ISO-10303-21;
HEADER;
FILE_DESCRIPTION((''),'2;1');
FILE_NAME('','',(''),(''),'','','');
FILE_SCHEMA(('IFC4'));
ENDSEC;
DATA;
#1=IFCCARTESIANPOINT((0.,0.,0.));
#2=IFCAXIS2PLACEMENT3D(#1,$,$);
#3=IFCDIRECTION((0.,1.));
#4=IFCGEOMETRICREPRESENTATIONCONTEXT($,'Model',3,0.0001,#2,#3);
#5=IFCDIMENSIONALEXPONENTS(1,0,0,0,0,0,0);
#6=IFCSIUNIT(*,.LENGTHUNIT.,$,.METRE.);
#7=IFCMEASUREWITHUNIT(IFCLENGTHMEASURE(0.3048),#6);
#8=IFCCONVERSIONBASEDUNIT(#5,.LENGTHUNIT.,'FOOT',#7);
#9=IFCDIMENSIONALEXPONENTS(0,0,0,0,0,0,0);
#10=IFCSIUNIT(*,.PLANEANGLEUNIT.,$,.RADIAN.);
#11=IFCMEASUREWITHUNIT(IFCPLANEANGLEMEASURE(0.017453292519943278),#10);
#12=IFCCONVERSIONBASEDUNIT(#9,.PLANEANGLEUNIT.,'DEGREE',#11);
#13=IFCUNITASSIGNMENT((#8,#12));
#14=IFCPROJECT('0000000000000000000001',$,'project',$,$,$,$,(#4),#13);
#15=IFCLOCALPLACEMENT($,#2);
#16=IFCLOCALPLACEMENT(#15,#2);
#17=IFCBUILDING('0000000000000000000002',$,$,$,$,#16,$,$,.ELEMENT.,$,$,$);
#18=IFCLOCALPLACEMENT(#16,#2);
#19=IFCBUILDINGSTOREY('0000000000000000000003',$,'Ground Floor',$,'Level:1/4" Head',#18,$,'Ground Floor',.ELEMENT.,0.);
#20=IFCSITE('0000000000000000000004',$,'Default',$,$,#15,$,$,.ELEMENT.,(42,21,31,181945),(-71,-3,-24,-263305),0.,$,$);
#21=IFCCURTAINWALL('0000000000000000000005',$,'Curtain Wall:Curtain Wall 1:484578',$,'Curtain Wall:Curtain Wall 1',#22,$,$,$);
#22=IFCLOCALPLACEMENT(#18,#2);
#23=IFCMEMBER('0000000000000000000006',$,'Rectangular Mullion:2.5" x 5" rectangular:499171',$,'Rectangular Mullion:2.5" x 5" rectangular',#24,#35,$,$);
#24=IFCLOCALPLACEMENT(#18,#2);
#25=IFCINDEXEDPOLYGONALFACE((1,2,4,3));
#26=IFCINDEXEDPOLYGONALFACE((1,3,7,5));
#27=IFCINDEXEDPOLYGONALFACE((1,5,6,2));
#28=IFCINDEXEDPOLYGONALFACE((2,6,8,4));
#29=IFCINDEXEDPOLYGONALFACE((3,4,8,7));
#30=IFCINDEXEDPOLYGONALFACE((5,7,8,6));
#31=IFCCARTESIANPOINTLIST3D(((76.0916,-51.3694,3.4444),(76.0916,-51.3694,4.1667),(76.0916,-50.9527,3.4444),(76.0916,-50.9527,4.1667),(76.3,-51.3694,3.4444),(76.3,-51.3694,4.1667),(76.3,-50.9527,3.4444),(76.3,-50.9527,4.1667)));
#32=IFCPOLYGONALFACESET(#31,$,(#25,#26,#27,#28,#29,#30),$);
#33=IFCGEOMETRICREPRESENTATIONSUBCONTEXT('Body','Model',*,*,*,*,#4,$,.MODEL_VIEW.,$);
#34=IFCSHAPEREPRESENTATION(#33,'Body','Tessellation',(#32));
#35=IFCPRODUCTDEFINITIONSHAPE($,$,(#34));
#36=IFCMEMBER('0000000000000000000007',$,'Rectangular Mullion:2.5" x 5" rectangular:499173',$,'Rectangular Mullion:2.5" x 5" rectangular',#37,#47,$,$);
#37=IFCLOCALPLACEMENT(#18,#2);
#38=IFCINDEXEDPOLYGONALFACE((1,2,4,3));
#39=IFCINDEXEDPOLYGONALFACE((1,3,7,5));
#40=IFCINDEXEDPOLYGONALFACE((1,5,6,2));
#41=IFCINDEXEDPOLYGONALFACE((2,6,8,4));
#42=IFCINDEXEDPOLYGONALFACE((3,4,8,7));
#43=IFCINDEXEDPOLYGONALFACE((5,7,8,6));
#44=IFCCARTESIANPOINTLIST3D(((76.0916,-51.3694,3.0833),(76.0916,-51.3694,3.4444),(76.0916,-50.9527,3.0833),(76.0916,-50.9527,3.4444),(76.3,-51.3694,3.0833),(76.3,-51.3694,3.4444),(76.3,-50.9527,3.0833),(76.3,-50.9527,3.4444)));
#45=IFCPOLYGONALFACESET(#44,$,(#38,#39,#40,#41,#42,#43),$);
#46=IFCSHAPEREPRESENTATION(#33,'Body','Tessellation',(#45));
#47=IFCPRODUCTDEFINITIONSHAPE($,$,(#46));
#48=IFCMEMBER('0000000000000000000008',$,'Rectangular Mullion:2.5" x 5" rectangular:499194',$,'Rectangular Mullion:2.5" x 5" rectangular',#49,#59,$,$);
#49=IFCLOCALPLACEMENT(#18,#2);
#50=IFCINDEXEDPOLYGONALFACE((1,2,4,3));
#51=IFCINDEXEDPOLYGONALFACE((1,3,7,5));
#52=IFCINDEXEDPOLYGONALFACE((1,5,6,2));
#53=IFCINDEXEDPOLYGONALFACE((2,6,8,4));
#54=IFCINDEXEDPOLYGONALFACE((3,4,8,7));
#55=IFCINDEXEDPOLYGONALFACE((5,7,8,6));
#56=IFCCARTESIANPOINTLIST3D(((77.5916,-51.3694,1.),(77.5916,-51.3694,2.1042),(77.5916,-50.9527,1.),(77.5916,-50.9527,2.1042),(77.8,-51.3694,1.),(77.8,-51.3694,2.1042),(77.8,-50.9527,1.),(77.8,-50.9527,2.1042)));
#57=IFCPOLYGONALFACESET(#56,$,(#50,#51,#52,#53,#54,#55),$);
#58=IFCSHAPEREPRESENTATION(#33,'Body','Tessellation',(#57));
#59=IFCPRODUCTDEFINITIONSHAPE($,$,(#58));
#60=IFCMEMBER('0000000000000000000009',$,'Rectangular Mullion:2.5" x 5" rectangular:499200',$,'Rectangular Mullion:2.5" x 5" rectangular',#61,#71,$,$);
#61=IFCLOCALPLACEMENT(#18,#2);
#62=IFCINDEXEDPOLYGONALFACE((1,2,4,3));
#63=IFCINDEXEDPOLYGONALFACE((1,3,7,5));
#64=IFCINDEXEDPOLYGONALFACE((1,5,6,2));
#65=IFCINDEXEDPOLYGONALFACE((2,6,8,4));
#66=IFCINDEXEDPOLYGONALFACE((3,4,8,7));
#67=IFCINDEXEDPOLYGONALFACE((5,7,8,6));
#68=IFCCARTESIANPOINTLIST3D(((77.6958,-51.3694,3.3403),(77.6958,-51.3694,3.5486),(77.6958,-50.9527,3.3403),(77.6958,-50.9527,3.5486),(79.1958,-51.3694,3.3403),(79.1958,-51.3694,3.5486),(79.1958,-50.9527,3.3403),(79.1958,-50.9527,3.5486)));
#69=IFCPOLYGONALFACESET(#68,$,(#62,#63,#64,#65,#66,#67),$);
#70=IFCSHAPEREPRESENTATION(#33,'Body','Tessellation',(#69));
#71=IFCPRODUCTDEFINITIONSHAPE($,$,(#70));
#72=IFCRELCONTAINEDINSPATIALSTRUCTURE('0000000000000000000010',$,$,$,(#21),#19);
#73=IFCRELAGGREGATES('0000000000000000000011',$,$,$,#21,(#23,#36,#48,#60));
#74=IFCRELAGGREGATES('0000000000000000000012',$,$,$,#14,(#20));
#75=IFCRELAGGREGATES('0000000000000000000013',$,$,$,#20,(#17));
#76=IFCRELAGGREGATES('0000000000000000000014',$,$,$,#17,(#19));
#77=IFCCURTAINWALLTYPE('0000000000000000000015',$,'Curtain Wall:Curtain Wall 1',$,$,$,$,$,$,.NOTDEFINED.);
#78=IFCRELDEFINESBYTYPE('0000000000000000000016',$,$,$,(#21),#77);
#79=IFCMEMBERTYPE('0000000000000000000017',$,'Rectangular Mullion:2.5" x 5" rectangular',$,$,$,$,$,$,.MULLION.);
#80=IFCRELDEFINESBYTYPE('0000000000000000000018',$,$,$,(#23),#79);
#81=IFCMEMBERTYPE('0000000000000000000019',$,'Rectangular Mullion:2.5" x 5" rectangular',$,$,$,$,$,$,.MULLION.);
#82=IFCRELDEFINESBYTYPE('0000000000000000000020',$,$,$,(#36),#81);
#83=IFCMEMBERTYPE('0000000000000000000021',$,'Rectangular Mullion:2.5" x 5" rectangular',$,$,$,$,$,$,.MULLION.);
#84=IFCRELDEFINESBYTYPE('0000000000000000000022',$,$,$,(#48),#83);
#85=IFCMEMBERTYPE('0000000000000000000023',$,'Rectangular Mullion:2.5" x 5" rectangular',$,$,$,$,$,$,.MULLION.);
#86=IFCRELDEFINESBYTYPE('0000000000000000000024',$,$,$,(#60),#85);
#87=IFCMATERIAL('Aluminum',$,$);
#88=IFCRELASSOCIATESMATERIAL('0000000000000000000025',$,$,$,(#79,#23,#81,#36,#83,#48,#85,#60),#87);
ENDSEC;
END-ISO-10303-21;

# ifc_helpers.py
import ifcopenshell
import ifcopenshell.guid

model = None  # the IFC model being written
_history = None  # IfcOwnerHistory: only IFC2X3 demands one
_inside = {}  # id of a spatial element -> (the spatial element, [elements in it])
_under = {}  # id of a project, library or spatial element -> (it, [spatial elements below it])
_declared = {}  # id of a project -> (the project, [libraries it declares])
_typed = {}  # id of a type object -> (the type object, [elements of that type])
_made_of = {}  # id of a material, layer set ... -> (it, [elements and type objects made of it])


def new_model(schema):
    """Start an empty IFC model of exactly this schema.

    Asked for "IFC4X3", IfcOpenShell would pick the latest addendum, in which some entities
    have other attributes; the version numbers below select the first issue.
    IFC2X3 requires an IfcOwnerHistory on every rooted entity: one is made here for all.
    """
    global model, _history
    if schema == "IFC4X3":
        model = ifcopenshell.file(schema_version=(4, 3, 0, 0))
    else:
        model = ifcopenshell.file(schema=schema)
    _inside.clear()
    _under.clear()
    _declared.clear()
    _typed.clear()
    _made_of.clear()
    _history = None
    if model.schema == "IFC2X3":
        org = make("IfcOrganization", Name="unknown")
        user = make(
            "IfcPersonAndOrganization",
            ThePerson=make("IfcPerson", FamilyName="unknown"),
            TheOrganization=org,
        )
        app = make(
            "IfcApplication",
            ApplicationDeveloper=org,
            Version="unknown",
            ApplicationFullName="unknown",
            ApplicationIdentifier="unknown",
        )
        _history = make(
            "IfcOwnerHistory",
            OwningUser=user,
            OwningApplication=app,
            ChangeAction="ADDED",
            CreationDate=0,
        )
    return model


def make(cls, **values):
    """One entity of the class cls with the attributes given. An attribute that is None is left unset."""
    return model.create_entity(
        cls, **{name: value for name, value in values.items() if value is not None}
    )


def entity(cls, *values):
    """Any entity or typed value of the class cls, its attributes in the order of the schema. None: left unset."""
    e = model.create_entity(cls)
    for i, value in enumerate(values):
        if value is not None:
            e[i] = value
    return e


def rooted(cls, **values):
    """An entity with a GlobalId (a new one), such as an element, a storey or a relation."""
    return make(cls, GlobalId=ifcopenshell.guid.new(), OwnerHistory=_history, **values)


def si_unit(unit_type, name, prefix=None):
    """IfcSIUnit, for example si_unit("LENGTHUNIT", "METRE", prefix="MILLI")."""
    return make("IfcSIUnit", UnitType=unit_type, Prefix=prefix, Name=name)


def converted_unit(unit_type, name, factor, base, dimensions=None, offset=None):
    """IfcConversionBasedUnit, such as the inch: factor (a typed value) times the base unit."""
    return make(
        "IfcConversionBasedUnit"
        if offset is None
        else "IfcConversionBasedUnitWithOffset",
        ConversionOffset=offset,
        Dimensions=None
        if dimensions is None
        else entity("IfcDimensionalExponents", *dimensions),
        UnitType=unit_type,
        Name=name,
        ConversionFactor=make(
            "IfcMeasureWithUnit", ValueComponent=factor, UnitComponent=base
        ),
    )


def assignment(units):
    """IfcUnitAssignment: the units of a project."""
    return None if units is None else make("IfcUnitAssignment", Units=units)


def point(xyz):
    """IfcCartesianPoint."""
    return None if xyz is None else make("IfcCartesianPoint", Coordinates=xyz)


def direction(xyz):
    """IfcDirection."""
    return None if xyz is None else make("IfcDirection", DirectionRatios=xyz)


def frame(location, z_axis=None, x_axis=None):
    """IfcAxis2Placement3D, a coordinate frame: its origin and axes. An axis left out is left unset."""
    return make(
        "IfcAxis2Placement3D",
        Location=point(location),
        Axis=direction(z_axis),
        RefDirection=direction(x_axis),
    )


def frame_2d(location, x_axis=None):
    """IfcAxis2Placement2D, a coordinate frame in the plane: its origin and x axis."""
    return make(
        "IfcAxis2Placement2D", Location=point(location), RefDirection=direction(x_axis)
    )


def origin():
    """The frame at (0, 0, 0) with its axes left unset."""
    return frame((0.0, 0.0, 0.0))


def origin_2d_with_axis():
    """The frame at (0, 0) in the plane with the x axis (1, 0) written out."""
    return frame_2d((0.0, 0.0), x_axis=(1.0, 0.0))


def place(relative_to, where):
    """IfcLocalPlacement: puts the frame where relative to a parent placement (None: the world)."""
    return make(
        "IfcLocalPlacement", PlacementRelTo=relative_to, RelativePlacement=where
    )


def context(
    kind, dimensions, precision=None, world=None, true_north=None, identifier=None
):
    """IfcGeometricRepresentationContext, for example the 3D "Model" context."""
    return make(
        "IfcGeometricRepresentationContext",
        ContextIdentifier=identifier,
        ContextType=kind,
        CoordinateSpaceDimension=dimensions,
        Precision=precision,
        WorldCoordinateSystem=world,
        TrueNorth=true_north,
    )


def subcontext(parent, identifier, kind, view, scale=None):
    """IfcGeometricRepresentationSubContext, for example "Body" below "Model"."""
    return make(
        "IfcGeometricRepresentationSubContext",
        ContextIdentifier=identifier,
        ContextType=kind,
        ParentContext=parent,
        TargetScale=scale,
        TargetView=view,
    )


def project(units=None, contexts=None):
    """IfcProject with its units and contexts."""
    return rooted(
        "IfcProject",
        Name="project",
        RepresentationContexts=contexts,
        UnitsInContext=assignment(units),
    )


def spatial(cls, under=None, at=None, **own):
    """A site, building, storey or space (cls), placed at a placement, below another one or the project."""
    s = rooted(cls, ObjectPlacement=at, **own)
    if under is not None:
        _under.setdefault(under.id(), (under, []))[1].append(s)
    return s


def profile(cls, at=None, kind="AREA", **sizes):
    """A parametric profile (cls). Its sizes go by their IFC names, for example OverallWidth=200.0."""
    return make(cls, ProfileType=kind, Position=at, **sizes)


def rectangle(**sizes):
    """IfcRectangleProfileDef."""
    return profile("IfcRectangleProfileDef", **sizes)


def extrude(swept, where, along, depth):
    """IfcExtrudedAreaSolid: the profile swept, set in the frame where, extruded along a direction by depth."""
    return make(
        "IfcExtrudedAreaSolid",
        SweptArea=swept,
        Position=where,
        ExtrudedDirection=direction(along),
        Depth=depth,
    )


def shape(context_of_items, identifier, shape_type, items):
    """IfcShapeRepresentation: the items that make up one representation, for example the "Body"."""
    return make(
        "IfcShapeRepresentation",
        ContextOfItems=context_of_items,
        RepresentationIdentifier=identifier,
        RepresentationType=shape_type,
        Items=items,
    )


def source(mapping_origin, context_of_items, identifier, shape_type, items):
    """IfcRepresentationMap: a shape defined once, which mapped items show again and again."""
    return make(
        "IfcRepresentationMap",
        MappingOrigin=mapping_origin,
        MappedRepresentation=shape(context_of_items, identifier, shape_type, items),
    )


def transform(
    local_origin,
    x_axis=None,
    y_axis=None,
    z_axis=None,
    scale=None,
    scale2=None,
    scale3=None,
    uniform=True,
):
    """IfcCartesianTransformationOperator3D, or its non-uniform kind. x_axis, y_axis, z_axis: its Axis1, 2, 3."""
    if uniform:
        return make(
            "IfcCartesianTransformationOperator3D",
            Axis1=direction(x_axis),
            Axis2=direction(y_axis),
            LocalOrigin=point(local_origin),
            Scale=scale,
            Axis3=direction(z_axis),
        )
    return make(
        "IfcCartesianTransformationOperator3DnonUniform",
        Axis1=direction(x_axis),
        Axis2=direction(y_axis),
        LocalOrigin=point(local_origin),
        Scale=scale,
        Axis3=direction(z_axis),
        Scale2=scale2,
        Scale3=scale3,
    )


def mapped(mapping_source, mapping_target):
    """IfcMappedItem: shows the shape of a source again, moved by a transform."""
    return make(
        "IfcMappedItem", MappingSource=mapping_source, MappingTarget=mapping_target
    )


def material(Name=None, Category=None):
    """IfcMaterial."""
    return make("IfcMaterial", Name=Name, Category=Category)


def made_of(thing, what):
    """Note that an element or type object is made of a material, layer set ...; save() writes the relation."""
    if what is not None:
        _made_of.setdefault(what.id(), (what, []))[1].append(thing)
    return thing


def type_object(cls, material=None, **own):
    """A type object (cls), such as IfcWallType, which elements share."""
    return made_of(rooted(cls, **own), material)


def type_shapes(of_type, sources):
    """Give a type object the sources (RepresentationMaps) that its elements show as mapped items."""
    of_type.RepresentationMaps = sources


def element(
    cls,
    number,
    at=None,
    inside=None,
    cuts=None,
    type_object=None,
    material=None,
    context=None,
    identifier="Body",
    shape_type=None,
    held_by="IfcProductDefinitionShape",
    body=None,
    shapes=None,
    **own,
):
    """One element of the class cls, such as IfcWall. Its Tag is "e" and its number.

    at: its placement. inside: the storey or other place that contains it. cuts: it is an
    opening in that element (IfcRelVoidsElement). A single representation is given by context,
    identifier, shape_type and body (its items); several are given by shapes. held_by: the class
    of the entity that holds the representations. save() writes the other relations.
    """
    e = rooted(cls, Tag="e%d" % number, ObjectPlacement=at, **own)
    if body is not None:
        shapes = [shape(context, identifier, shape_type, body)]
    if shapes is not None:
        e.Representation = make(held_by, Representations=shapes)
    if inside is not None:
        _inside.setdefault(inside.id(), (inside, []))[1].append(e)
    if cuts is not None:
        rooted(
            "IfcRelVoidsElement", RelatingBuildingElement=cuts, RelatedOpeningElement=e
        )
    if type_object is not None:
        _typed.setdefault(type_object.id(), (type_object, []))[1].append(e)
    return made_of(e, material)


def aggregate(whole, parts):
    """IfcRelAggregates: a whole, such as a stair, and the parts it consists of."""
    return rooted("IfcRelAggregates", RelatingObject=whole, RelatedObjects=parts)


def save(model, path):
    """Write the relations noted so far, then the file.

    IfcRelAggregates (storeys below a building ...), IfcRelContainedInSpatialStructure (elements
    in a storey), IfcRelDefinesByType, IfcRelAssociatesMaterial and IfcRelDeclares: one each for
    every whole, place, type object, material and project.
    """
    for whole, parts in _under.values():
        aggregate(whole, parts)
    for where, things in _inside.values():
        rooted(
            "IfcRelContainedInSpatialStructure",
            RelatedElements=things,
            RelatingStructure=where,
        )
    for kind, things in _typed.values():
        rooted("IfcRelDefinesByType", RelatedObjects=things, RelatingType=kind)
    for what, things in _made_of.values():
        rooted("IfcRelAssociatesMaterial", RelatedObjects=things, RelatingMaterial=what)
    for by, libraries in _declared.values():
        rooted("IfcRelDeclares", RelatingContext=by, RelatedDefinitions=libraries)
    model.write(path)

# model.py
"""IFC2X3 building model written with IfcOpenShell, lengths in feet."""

from ifc_helpers import new_model, entity, si_unit, converted_unit, direction, frame, origin, origin_2d_with_axis, place, context, subcontext, project, spatial, rectangle, extrude, source, transform, mapped, material, type_object, type_shapes, element, aggregate, save


model = new_model("IFC2X3")

# Units and contexts
model_context = context("Model", 3, precision=0.0001, world=origin(), true_north=direction((0.0, 1.0)))
body_context = subcontext(model_context, "Body", "Model", "MODEL_VIEW")
ifc_project = project(units=[converted_unit("LENGTHUNIT", "FOOT", entity("IfcLengthMeasure", 0.3048), si_unit("LENGTHUNIT", "METRE"), dimensions=[1, 0, 0, 0, 0, 0, 0]), converted_unit("PLANEANGLEUNIT", "DEGREE", entity("IfcPlaneAngleMeasure", 0.017453292519943278), si_unit("PLANEANGLEUNIT", "RADIAN"), dimensions=[0, 0, 0, 0, 0, 0, 0])], contexts=[model_context])

# Site, building, storey
site_placement = place(None, origin())
site = spatial("IfcSite", under=ifc_project, at=site_placement, Name="Default", CompositionType="ELEMENT", RefLatitude=(42, 21, 31, 181945), RefLongitude=(-71, -3, -24, -263305), RefElevation=0.0)
building_placement = place(site_placement, origin())
building = spatial("IfcBuilding", under=site, at=building_placement, CompositionType="ELEMENT")
storey_placement = place(building_placement, origin())
storey = spatial("IfcBuildingStorey", under=building, at=storey_placement, Name="Ground Floor", ObjectType="Level:1/4\" Head", LongName="Ground Floor", CompositionType="ELEMENT", Elevation=0.0)

# Curtain wall, members
curtain_wall_type = type_object("IfcCurtainWallType", Name="Curtain Wall:Curtain Wall 1", PredefinedType="NOTDEFINED")
curtain_wall_placement = place(storey_placement, origin())
curtain_wall = element("IfcCurtainWall", 1, at=curtain_wall_placement, inside=storey, type_object=curtain_wall_type, Name="Curtain Wall:Curtain Wall 1:484578", ObjectType="Curtain Wall:Curtain Wall 1")
ifc_material_1 = material(Name="Aluminum")
member_type_1 = type_object("IfcMemberType", Name="Rectangular Mullion:2.5\" x 5\" rectangular", PredefinedType="MULLION", material=ifc_material_1)
shared_shape_1 = source(origin(), body_context, "Body", "SweptSolid", [
    extrude(rectangle(XDim=0.2083, YDim=0.4167, at=origin_2d_with_axis()), frame((0.0, 0.0, -0.7222), z_axis=(0.0, 0.0, 1.0), x_axis=(-1.0, 0.0, 0.0)), (0.0, 0.0, 1.0), 0.7222),
])
type_shapes(member_type_1, [shared_shape_1])
member_1_placement = place(curtain_wall_placement, frame((76.1958, -51.161, 3.4444), z_axis=(0.0, 0.0, -1.0), x_axis=(1.0, 0.0, 0.0)))
member_1 = element("IfcMember", 2, at=member_1_placement, type_object=member_type_1, material=ifc_material_1, Name="Rectangular Mullion:2.5\" x 5\" rectangular:499171", ObjectType="Rectangular Mullion:2.5\" x 5\" rectangular", context=body_context, shape_type="MappedRepresentation", body=[
    mapped(shared_shape_1, transform((0.0, 0.0, 0.0), scale=1.0)),
])
member_type_2 = type_object("IfcMemberType", Name="Rectangular Mullion:2.5\" x 5\" rectangular", PredefinedType="MULLION", material=ifc_material_1)
shared_shape_2 = source(origin(), body_context, "Body", "SweptSolid", [
    extrude(rectangle(XDim=0.2083, YDim=0.4167, at=origin_2d_with_axis()), frame((0.0, 0.0, -0.3611), z_axis=(0.0, 0.0, 1.0), x_axis=(-1.0, 0.0, 0.0)), (0.0, 0.0, 1.0), 0.3611),
])
type_shapes(member_type_2, [shared_shape_2])
member_2_placement = place(curtain_wall_placement, frame((76.1958, -51.161, 3.0833), z_axis=(0.0, 0.0, -1.0), x_axis=(1.0, 0.0, 0.0)))
member_2 = element("IfcMember", 3, at=member_2_placement, type_object=member_type_2, material=ifc_material_1, Name="Rectangular Mullion:2.5\" x 5\" rectangular:499173", ObjectType="Rectangular Mullion:2.5\" x 5\" rectangular", context=body_context, shape_type="MappedRepresentation", body=[
    mapped(shared_shape_2, transform((0.0, 0.0, 0.0), scale=1.0)),
])
member_type_3 = type_object("IfcMemberType", Name="Rectangular Mullion:2.5\" x 5\" rectangular", PredefinedType="MULLION", material=ifc_material_1)
shared_shape_3 = source(origin(), body_context, "Body", "SweptSolid", [
    extrude(rectangle(XDim=0.2083, YDim=0.4167, at=origin_2d_with_axis()), frame((0.0, 0.0, -1.1042), z_axis=(0.0, 0.0, 1.0), x_axis=(-1.0, 0.0, 0.0)), (0.0, 0.0, 1.0), 1.1042),
])
type_shapes(member_type_3, [shared_shape_3])
member_3_placement = place(curtain_wall_placement, frame((77.6958, -51.161, 1.0), z_axis=(0.0, 0.0, -1.0), x_axis=(1.0, 0.0, 0.0)))
member_3 = element("IfcMember", 4, at=member_3_placement, type_object=member_type_3, material=ifc_material_1, Name="Rectangular Mullion:2.5\" x 5\" rectangular:499194", ObjectType="Rectangular Mullion:2.5\" x 5\" rectangular", context=body_context, shape_type="MappedRepresentation", body=[
    mapped(shared_shape_3, transform((0.0, 0.0, 0.0), scale=1.0)),
])
member_type_4 = type_object("IfcMemberType", Name="Rectangular Mullion:2.5\" x 5\" rectangular", PredefinedType="MULLION", material=ifc_material_1)
shared_shape_4 = source(origin(), body_context, "Body", "SweptSolid", [
    extrude(rectangle(XDim=0.2083, YDim=0.4167, at=origin_2d_with_axis()), frame((0.0, 0.0, -1.5), z_axis=(0.0, 0.0, 1.0), x_axis=(-1.0, 0.0, 0.0)), (0.0, 0.0, 1.0), 1.5),
])
type_shapes(member_type_4, [shared_shape_4])
member_4_placement = place(curtain_wall_placement, frame((79.1958, -51.161, 3.4444), z_axis=(1.0, 0.0, 0.0), x_axis=(0.0, 0.0, 1.0)))
member_4 = element("IfcMember", 5, at=member_4_placement, type_object=member_type_4, material=ifc_material_1, Name="Rectangular Mullion:2.5\" x 5\" rectangular:499200", ObjectType="Rectangular Mullion:2.5\" x 5\" rectangular", context=body_context, shape_type="MappedRepresentation", body=[
    mapped(shared_shape_4, transform((0.0, 0.0, 0.0), scale=1.0)),
])
aggregate(curtain_wall, [member_1, member_2, member_3, member_4])

save(model, "model.ifc")
